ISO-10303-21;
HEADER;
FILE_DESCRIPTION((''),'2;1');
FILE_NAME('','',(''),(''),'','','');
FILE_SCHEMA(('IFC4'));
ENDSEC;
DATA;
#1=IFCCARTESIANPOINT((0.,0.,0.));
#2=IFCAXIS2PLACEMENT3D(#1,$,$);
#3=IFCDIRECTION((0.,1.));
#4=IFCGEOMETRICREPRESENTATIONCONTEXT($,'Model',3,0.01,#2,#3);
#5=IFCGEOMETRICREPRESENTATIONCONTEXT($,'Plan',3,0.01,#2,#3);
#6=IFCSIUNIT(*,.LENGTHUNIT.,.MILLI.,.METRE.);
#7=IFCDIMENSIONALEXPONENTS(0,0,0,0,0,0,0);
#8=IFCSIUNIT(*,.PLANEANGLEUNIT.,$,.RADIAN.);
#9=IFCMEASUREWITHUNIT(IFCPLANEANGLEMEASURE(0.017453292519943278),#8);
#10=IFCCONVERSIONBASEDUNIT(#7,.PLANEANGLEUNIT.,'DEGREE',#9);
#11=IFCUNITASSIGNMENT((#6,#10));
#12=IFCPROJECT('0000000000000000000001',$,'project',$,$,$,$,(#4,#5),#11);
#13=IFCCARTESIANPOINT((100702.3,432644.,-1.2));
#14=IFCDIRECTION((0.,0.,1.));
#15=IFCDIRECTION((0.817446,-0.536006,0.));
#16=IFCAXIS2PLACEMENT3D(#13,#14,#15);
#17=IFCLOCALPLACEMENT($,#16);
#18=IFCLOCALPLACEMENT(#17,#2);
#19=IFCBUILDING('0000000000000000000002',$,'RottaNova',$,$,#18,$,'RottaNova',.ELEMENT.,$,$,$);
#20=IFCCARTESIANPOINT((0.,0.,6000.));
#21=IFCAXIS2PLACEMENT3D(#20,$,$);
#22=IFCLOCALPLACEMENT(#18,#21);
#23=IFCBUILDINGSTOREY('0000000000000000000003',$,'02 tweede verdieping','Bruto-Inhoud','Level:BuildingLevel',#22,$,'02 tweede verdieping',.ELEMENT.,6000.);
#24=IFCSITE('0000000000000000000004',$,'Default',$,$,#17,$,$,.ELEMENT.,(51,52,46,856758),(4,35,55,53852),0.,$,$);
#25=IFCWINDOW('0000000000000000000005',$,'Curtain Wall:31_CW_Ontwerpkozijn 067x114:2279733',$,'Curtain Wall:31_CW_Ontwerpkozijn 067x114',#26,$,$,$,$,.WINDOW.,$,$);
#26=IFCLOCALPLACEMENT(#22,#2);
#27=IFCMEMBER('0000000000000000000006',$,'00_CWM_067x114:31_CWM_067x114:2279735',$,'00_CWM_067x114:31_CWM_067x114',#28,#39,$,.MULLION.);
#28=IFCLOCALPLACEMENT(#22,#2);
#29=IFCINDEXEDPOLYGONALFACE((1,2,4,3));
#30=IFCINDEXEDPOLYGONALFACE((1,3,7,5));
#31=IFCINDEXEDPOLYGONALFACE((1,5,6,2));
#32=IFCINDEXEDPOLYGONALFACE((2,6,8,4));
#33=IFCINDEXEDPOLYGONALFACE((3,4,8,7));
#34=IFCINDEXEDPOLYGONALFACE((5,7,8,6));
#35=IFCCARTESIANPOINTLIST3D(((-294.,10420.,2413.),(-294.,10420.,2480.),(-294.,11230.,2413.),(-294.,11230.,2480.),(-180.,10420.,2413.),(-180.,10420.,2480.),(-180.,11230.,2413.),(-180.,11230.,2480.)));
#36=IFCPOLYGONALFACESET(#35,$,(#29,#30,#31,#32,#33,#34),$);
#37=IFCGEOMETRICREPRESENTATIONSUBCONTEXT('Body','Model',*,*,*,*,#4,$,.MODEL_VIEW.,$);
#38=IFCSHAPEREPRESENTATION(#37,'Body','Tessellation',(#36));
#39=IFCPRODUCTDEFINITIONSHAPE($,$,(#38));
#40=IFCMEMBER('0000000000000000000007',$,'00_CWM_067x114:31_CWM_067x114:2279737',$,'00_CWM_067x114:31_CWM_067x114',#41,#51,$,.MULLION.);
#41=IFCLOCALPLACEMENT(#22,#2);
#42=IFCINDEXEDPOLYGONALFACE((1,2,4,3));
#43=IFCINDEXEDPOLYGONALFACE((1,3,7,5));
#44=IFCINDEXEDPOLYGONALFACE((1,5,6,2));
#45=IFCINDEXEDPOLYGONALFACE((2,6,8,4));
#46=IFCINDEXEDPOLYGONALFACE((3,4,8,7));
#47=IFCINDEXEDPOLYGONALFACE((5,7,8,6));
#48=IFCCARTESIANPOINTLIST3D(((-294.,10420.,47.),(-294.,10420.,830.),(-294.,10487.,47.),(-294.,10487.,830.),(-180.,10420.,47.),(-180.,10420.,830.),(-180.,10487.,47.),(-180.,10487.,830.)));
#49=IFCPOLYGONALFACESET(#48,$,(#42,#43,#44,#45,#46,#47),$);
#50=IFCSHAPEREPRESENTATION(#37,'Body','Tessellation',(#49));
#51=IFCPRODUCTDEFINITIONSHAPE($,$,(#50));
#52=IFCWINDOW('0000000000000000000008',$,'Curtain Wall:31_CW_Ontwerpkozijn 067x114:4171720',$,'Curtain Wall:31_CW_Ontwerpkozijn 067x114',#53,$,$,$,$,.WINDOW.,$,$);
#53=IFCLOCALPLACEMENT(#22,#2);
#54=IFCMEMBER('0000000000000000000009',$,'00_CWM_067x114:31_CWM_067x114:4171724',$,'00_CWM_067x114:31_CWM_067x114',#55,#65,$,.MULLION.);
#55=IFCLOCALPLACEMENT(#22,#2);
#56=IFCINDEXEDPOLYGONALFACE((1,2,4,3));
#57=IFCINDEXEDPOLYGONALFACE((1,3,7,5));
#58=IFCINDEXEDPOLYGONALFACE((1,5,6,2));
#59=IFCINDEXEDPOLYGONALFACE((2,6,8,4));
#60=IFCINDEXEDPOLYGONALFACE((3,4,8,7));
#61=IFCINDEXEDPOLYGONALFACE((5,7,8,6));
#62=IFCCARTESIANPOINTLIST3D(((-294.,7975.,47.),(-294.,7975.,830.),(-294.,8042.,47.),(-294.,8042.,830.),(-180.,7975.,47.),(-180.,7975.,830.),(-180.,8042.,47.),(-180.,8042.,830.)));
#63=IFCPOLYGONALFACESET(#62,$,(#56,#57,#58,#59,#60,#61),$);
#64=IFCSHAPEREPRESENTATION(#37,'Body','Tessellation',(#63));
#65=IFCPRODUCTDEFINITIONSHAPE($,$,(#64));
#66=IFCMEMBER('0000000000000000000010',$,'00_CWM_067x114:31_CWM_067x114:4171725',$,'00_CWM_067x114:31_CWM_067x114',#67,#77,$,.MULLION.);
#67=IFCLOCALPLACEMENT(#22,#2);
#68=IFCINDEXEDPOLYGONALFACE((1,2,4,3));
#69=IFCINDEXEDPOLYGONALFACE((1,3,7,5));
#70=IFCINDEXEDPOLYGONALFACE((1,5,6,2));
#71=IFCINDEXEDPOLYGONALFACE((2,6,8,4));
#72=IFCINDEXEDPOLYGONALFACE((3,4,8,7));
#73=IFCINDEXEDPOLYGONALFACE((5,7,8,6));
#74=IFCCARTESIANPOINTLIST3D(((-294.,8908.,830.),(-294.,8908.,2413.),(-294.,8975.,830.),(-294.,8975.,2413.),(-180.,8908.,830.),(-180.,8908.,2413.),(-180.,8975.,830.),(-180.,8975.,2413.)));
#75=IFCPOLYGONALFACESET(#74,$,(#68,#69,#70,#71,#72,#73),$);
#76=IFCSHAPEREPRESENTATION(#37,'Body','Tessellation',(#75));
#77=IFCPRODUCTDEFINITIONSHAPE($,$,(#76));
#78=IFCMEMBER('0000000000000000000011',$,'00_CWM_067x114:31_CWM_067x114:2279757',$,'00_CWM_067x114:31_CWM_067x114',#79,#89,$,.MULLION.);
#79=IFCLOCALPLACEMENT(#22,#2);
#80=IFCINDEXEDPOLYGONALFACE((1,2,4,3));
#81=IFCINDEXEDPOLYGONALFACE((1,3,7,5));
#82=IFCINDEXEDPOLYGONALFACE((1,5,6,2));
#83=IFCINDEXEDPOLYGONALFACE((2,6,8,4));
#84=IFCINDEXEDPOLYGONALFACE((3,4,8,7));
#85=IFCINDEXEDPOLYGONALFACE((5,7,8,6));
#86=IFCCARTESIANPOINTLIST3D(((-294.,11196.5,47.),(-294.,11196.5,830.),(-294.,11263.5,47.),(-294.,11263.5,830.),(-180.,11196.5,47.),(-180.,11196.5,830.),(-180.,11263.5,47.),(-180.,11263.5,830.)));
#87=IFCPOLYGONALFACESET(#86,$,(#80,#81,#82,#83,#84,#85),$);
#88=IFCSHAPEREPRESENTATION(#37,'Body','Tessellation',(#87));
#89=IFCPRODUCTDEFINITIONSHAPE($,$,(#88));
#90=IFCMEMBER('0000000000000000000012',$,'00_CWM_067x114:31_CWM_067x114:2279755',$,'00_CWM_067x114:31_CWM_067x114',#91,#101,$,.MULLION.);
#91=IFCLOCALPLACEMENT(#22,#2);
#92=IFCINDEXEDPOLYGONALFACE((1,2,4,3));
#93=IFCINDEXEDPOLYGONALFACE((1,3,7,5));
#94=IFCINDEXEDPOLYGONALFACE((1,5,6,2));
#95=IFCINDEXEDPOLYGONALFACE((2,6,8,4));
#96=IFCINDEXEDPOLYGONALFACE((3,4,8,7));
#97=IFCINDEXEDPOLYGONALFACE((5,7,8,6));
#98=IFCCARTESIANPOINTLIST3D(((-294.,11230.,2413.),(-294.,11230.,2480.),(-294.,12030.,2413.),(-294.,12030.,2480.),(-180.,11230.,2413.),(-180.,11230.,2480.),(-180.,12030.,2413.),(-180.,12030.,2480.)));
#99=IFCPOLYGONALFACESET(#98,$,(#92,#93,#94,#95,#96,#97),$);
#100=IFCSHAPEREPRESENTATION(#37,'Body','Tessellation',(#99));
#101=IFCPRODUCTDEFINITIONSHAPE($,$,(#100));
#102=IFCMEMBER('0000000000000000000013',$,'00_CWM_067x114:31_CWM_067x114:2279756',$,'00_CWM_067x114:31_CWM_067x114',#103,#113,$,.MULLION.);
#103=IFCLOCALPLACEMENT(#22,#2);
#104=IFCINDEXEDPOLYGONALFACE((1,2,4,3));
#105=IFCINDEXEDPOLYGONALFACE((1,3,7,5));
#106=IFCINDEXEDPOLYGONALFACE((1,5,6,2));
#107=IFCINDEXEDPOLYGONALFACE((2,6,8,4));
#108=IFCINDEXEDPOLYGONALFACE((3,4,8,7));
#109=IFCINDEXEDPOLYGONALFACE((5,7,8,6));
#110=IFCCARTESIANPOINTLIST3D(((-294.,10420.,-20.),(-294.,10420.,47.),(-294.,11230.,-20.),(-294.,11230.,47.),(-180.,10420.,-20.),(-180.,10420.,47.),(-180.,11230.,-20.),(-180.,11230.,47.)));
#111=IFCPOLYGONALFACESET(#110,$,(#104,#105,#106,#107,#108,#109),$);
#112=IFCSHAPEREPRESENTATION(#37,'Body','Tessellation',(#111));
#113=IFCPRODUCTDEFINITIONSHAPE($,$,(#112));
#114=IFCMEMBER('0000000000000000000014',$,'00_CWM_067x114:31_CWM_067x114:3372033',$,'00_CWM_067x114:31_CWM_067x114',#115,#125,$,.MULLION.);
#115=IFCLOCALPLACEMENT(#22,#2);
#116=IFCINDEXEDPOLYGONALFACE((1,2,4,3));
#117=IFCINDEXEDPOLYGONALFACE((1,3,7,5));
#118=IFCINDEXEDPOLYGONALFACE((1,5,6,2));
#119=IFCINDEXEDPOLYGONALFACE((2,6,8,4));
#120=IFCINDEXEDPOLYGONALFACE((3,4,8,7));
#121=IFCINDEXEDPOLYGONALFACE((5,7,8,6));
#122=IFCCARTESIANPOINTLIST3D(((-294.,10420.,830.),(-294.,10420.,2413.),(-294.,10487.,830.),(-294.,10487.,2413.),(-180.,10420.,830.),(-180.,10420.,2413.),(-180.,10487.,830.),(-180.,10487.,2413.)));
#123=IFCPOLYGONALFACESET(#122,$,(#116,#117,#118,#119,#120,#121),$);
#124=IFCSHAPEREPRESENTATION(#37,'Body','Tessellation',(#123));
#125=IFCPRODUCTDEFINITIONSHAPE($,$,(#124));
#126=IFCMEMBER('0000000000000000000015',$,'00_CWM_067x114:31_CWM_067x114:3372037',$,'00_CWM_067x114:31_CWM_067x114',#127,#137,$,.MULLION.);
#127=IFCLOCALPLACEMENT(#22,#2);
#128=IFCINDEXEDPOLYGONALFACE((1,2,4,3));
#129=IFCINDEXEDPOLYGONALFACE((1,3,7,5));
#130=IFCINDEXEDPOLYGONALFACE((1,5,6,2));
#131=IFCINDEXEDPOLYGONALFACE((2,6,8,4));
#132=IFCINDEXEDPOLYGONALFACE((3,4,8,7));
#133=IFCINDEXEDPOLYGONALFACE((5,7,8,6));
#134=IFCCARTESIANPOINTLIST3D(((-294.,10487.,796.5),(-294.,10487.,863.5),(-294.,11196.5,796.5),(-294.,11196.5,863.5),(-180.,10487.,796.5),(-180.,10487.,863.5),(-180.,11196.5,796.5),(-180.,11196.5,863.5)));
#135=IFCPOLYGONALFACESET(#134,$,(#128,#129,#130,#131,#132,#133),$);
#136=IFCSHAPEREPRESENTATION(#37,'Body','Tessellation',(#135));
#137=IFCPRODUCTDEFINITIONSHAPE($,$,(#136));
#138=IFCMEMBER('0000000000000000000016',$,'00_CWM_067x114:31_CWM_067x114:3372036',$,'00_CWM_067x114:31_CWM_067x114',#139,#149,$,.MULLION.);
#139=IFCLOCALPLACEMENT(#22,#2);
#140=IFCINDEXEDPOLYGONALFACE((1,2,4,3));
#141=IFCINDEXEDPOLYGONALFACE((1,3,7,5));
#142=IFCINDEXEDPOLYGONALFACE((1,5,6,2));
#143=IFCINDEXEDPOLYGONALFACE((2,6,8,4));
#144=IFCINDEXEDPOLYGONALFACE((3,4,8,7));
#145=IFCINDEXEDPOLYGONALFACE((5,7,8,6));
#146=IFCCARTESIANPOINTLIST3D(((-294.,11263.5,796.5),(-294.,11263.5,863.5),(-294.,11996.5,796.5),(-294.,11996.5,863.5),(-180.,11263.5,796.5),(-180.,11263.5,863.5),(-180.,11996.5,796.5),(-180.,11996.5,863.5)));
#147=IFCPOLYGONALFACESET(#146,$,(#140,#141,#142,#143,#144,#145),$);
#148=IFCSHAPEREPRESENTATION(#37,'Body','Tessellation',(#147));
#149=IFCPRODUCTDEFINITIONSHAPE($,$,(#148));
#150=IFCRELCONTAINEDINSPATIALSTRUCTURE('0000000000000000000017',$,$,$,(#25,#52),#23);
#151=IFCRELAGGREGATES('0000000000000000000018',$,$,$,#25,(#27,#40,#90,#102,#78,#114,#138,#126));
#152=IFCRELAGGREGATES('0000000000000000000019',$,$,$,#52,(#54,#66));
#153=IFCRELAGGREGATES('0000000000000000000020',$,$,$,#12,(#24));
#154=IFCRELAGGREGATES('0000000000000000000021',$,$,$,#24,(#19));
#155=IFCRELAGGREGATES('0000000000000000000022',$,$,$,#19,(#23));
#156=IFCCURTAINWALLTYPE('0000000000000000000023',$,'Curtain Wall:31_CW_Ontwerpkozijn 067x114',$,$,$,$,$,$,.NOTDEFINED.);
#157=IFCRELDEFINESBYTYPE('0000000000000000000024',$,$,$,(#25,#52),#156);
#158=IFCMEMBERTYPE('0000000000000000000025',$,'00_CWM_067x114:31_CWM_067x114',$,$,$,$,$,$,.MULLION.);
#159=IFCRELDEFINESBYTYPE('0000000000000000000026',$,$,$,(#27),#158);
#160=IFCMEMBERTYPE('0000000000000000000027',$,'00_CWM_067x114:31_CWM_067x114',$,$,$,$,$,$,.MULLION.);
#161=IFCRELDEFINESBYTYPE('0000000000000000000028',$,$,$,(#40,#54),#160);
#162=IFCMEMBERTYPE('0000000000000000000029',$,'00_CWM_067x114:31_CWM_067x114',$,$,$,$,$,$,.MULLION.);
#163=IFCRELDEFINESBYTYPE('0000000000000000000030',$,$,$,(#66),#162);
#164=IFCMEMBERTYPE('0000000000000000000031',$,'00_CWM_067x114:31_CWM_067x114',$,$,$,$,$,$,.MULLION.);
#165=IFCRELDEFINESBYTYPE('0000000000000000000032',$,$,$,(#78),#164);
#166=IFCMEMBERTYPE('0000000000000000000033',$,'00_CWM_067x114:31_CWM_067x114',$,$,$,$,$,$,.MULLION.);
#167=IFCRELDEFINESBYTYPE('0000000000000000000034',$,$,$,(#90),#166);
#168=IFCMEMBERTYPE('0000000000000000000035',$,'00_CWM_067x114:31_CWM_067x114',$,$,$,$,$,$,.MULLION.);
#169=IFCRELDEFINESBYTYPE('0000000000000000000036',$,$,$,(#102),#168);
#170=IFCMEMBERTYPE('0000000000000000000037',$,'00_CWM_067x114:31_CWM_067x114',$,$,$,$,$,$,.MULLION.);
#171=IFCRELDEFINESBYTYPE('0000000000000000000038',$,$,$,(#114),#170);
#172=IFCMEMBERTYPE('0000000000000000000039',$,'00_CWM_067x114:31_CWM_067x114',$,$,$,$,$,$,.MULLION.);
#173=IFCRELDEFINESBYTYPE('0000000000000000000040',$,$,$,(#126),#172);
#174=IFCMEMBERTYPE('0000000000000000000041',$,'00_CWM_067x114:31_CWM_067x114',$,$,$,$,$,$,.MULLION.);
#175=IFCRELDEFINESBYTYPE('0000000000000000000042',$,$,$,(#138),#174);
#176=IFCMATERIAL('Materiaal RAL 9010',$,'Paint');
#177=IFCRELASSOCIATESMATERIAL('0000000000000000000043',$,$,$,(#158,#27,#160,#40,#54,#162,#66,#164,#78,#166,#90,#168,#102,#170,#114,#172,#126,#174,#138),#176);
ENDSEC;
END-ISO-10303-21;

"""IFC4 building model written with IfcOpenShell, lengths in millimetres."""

from ifc_helpers import new_model, entity, si_unit, converted_unit, direction, frame, origin, place, context, subcontext, project, spatial, indexed_curve, outline, extrude, source, transform, mapped, material, type_object, type_shapes, element, aggregate, save


model = new_model("IFC4")

# Units and contexts
model_context = context("Model", 3, precision=0.01, world=origin(), true_north=direction((0.0, 1.0)))
plan_context = context("Plan", 3, precision=0.01, world=origin(), true_north=direction((0.0, 1.0)))
body_context = subcontext(model_context, "Body", "Model", "MODEL_VIEW")
ifc_project = project(units=[si_unit("LENGTHUNIT", "METRE", prefix="MILLI"), converted_unit("PLANEANGLEUNIT", "DEGREE", entity("IfcPlaneAngleMeasure", 0.017453292519943278), si_unit("PLANEANGLEUNIT", "RADIAN"), dimensions=[0, 0, 0, 0, 0, 0, 0])], contexts=[model_context, plan_context])

# Site, building, storey
site_placement = place(None, frame((100702.3, 432644.0, -1.2), z_axis=(0.0, 0.0, 1.0), x_axis=(0.817446, -0.536006, 0.0)))
site = spatial("IfcSite", under=ifc_project, at=site_placement, Name="Default", CompositionType="ELEMENT", RefLatitude=(51, 52, 46, 856758), RefLongitude=(4, 35, 55, 53852), RefElevation=0.0)
building_placement = place(site_placement, origin())
building = spatial("IfcBuilding", under=site, at=building_placement, Name="RottaNova", LongName="RottaNova", CompositionType="ELEMENT")
storey_placement = place(building_placement, frame((0.0, 0.0, 6000.0)))
storey = spatial("IfcBuildingStorey", under=building, at=storey_placement, Name="02 tweede verdieping", Description="Bruto-Inhoud", ObjectType="Level:BuildingLevel", LongName="02 tweede verdieping", CompositionType="ELEMENT", Elevation=6000.0)

# Windows, members
curtain_wall_type = type_object("IfcCurtainWallType", Name="Curtain Wall:31_CW_Ontwerpkozijn 067x114", PredefinedType="NOTDEFINED")
window_1_placement = place(storey_placement, frame((0.0, 0.0, -6000.0)))
window_1 = element("IfcWindow", 1, at=window_1_placement, inside=storey, type_object=curtain_wall_type, Name="Curtain Wall:31_CW_Ontwerpkozijn 067x114:2279733", ObjectType="Curtain Wall:31_CW_Ontwerpkozijn 067x114", PredefinedType="WINDOW")
ifc_material_1 = material(Name="Materiaal RAL 9010", Category="Paint")
member_type_1 = type_object("IfcMemberType", Name="00_CWM_067x114:31_CWM_067x114", PredefinedType="MULLION", material=ifc_material_1)
shared_shape_1 = source(origin(), body_context, "Body", "SweptSolid", [
    extrude(outline(indexed_curve([(-33.5, -57.0), (33.5, -57.0), (33.5, 57.0), (-33.5, 57.0), (-33.5, -57.0)], self_intersect=False)), frame((-33.5, 57.0, -810.0), z_axis=(0.0, 0.0, 1.0), x_axis=(-1.0, 0.0, 0.0)), (0.0, 0.0, 1.0), 810.0),
])
type_shapes(member_type_1, [shared_shape_1])
member_1_placement = place(window_1_placement, frame((-180.0, 10420.0, 8480.0), z_axis=(0.0, -1.0, 0.0), x_axis=(0.0, 0.0, 1.0)))
member_1 = element("IfcMember", 2, at=member_1_placement, type_object=member_type_1, material=ifc_material_1, Name="00_CWM_067x114:31_CWM_067x114:2279735", ObjectType="00_CWM_067x114:31_CWM_067x114", PredefinedType="MULLION", context=body_context, shape_type="MappedRepresentation", body=[
    mapped(shared_shape_1, transform((0.0, 0.0, 0.0), scale=1.0)),
])
member_type_2 = type_object("IfcMemberType", Name="00_CWM_067x114:31_CWM_067x114", PredefinedType="MULLION", material=ifc_material_1)
shared_shape_2 = source(origin(), body_context, "Body", "SweptSolid", [
    extrude(outline(indexed_curve([(-33.5, -57.0), (33.5, -57.0), (33.5, 57.0), (-33.5, 57.0), (-33.5, -57.0)], self_intersect=False)), frame((-33.5, 57.0, -783.0), z_axis=(0.0, 0.0, 1.0), x_axis=(-1.0, 0.0, 0.0)), (0.0, 0.0, 1.0), 783.0),
])
type_shapes(member_type_2, [shared_shape_2])
member_2_placement = place(window_1_placement, frame((-180.0, 10420.0, 6047.0), z_axis=(0.0, 0.0, -1.0), x_axis=(0.0, -1.0, 0.0)))
member_2 = element("IfcMember", 3, at=member_2_placement, type_object=member_type_2, material=ifc_material_1, Name="00_CWM_067x114:31_CWM_067x114:2279737", ObjectType="00_CWM_067x114:31_CWM_067x114", PredefinedType="MULLION", context=body_context, shape_type="MappedRepresentation", body=[
    mapped(shared_shape_2, transform((0.0, 0.0, 0.0), scale=1.0)),
])
window_2_placement = place(storey_placement, frame((0.0, 0.0, -6000.0)))
window_2 = element("IfcWindow", 4, at=window_2_placement, inside=storey, type_object=curtain_wall_type, Name="Curtain Wall:31_CW_Ontwerpkozijn 067x114:4171720", ObjectType="Curtain Wall:31_CW_Ontwerpkozijn 067x114", PredefinedType="WINDOW")
member_3_placement = place(window_2_placement, frame((-180.0, 7975.0, 6047.0), z_axis=(0.0, 0.0, -1.0), x_axis=(0.0, -1.0, 0.0)))
member_3 = element("IfcMember", 5, at=member_3_placement, type_object=member_type_2, material=ifc_material_1, Name="00_CWM_067x114:31_CWM_067x114:4171724", ObjectType="00_CWM_067x114:31_CWM_067x114", PredefinedType="MULLION", context=body_context, shape_type="MappedRepresentation", body=[
    mapped(shared_shape_2, transform((0.0, 0.0, 0.0), scale=1.0)),
])
member_type_3 = type_object("IfcMemberType", Name="00_CWM_067x114:31_CWM_067x114", PredefinedType="MULLION", material=ifc_material_1)
shared_shape_3 = source(origin(), body_context, "Body", "SweptSolid", [
    extrude(outline(indexed_curve([(-33.5, -57.0), (33.5, -57.0), (33.5, 57.0), (-33.5, 57.0), (-33.5, -57.0)], self_intersect=False)), frame((-33.5, 57.0, -1583.0), z_axis=(0.0, 0.0, 1.0), x_axis=(-1.0, 0.0, 0.0)), (0.0, 0.0, 1.0), 1583.0),
])
type_shapes(member_type_3, [shared_shape_3])
member_4_placement = place(window_2_placement, frame((-180.0, 8975.0, 8413.0), z_axis=(0.0, 0.0, 1.0), x_axis=(0.0, 1.0, 0.0)))
member_4 = element("IfcMember", 6, at=member_4_placement, type_object=member_type_3, material=ifc_material_1, Name="00_CWM_067x114:31_CWM_067x114:4171725", ObjectType="00_CWM_067x114:31_CWM_067x114", PredefinedType="MULLION", context=body_context, shape_type="MappedRepresentation", body=[
    mapped(shared_shape_3, transform((0.0, 0.0, 0.0), scale=1.0)),
])

# Members
member_type_4 = type_object("IfcMemberType", Name="00_CWM_067x114:31_CWM_067x114", PredefinedType="MULLION", material=ifc_material_1)
shared_shape_4 = source(origin(), body_context, "Body", "SweptSolid", [
    extrude(outline(indexed_curve([(-33.5, -57.0), (33.5, -57.0), (33.5, 57.0), (-33.5, 57.0), (-33.5, -57.0)], self_intersect=False)), frame((0.0, 57.0, -783.0), z_axis=(0.0, 0.0, 1.0), x_axis=(-1.0, 0.0, 0.0)), (0.0, 0.0, 1.0), 783.0),
])
type_shapes(member_type_4, [shared_shape_4])
member_5_placement = place(window_1_placement, frame((-180.0, 11230.0, 6047.0), z_axis=(0.0, 0.0, -1.0), x_axis=(0.0, -1.0, 0.0)))
member_5 = element("IfcMember", 7, at=member_5_placement, type_object=member_type_4, material=ifc_material_1, Name="00_CWM_067x114:31_CWM_067x114:2279757", ObjectType="00_CWM_067x114:31_CWM_067x114", PredefinedType="MULLION", context=body_context, shape_type="MappedRepresentation", body=[
    mapped(shared_shape_4, transform((0.0, 0.0, 0.0), scale=1.0)),
])
member_type_5 = type_object("IfcMemberType", Name="00_CWM_067x114:31_CWM_067x114", PredefinedType="MULLION", material=ifc_material_1)
shared_shape_5 = source(origin(), body_context, "Body", "SweptSolid", [
    extrude(outline(indexed_curve([(-33.5, -57.0), (33.5, -57.0), (33.5, 57.0), (-33.5, 57.0), (-33.5, -57.0)], self_intersect=False)), frame((-33.5, 57.0, -800.0), z_axis=(0.0, 0.0, 1.0), x_axis=(-1.0, 0.0, 0.0)), (0.0, 0.0, 1.0), 800.0),
])
type_shapes(member_type_5, [shared_shape_5])
member_6_placement = place(window_1_placement, frame((-180.0, 11230.0, 8480.0), z_axis=(0.0, -1.0, 0.0), x_axis=(0.0, 0.0, 1.0)))
member_6 = element("IfcMember", 8, at=member_6_placement, type_object=member_type_5, material=ifc_material_1, Name="00_CWM_067x114:31_CWM_067x114:2279755", ObjectType="00_CWM_067x114:31_CWM_067x114", PredefinedType="MULLION", context=body_context, shape_type="MappedRepresentation", body=[
    mapped(shared_shape_5, transform((0.0, 0.0, 0.0), scale=1.0)),
])
member_type_6 = type_object("IfcMemberType", Name="00_CWM_067x114:31_CWM_067x114", PredefinedType="MULLION", material=ifc_material_1)
shared_shape_6 = source(origin(), body_context, "Body", "SweptSolid", [
    extrude(outline(indexed_curve([(-33.5, -57.0), (33.5, -57.0), (33.5, 57.0), (-33.5, 57.0), (-33.5, -57.0)], self_intersect=False)), frame((-33.5, 57.0, -810.0), z_axis=(0.0, 0.0, 1.0), x_axis=(-1.0, 0.0, 0.0)), (0.0, 0.0, 1.0), 810.0),
])
type_shapes(member_type_6, [shared_shape_6])
member_7_placement = place(window_1_placement, frame((-180.0, 11230.0, 5980.0), z_axis=(0.0, 1.0, 0.0), x_axis=(0.0, 0.0, -1.0)))
member_7 = element("IfcMember", 9, at=member_7_placement, type_object=member_type_6, material=ifc_material_1, Name="00_CWM_067x114:31_CWM_067x114:2279756", ObjectType="00_CWM_067x114:31_CWM_067x114", PredefinedType="MULLION", context=body_context, shape_type="MappedRepresentation", body=[
    mapped(shared_shape_6, transform((0.0, 0.0, 0.0), scale=1.0)),
])
member_type_7 = type_object("IfcMemberType", Name="00_CWM_067x114:31_CWM_067x114", PredefinedType="MULLION", material=ifc_material_1)
shared_shape_7 = source(origin(), body_context, "Body", "SweptSolid", [
    extrude(outline(indexed_curve([(-33.5, -57.0), (33.5, -57.0), (33.5, 57.0), (-33.5, 57.0), (-33.5, -57.0)], self_intersect=False)), frame((-33.5, 57.0, -1583.0), z_axis=(0.0, 0.0, 1.0), x_axis=(-1.0, 0.0, 0.0)), (0.0, 0.0, 1.0), 1583.0),
])
type_shapes(member_type_7, [shared_shape_7])
member_8_placement = place(window_1_placement, frame((-180.0, 10420.0, 6830.0), z_axis=(0.0, 0.0, -1.0), x_axis=(0.0, -1.0, 0.0)))
member_8 = element("IfcMember", 10, at=member_8_placement, type_object=member_type_7, material=ifc_material_1, Name="00_CWM_067x114:31_CWM_067x114:3372033", ObjectType="00_CWM_067x114:31_CWM_067x114", PredefinedType="MULLION", context=body_context, shape_type="MappedRepresentation", body=[
    mapped(shared_shape_7, transform((0.0, 0.0, 0.0), scale=1.0)),
])
member_type_8 = type_object("IfcMemberType", Name="00_CWM_067x114:31_CWM_067x114", PredefinedType="MULLION", material=ifc_material_1)
shared_shape_8 = source(origin(), body_context, "Body", "SweptSolid", [
    extrude(outline(indexed_curve([(-33.5, -57.0), (33.5, -57.0), (33.5, 57.0), (-33.5, 57.0), (-33.5, -57.0)], self_intersect=False)), frame((0.0, 57.0, -709.5), z_axis=(0.0, 0.0, 1.0), x_axis=(-1.0, 0.0, 0.0)), (0.0, 0.0, 1.0), 709.5),
])
type_shapes(member_type_8, [shared_shape_8])
member_9_placement = place(window_1_placement, frame((-180.0, 10487.0, 6830.0), z_axis=(0.0, -1.0, 0.0), x_axis=(0.0, 0.0, 1.0)))
member_9 = element("IfcMember", 11, at=member_9_placement, type_object=member_type_8, material=ifc_material_1, Name="00_CWM_067x114:31_CWM_067x114:3372037", ObjectType="00_CWM_067x114:31_CWM_067x114", PredefinedType="MULLION", context=body_context, shape_type="MappedRepresentation", body=[
    mapped(shared_shape_8, transform((0.0, 0.0, 0.0), scale=1.0)),
])
member_type_9 = type_object("IfcMemberType", Name="00_CWM_067x114:31_CWM_067x114", PredefinedType="MULLION", material=ifc_material_1)
shared_shape_9 = source(origin(), body_context, "Body", "SweptSolid", [
    extrude(outline(indexed_curve([(-33.5, -57.0), (33.5, -57.0), (33.5, 57.0), (-33.5, 57.0), (-33.5, -57.0)], self_intersect=False)), frame((0.0, 57.0, -733.0), z_axis=(0.0, 0.0, 1.0), x_axis=(-1.0, 0.0, 0.0)), (0.0, 0.0, 1.0), 733.0),
])
type_shapes(member_type_9, [shared_shape_9])
member_10_placement = place(window_1_placement, frame((-180.0, 11263.5, 6830.0), z_axis=(0.0, -1.0, 0.0), x_axis=(0.0, 0.0, 1.0)))
member_10 = element("IfcMember", 12, at=member_10_placement, type_object=member_type_9, material=ifc_material_1, Name="00_CWM_067x114:31_CWM_067x114:3372036", ObjectType="00_CWM_067x114:31_CWM_067x114", PredefinedType="MULLION", context=body_context, shape_type="MappedRepresentation", body=[
    mapped(shared_shape_9, transform((0.0, 0.0, 0.0), scale=1.0)),
])

aggregate(window_1, [member_1, member_2, member_6, member_7, member_5, member_8, member_10, member_9])
aggregate(window_2, [member_3, member_4])

save(model, "model.ifc")
